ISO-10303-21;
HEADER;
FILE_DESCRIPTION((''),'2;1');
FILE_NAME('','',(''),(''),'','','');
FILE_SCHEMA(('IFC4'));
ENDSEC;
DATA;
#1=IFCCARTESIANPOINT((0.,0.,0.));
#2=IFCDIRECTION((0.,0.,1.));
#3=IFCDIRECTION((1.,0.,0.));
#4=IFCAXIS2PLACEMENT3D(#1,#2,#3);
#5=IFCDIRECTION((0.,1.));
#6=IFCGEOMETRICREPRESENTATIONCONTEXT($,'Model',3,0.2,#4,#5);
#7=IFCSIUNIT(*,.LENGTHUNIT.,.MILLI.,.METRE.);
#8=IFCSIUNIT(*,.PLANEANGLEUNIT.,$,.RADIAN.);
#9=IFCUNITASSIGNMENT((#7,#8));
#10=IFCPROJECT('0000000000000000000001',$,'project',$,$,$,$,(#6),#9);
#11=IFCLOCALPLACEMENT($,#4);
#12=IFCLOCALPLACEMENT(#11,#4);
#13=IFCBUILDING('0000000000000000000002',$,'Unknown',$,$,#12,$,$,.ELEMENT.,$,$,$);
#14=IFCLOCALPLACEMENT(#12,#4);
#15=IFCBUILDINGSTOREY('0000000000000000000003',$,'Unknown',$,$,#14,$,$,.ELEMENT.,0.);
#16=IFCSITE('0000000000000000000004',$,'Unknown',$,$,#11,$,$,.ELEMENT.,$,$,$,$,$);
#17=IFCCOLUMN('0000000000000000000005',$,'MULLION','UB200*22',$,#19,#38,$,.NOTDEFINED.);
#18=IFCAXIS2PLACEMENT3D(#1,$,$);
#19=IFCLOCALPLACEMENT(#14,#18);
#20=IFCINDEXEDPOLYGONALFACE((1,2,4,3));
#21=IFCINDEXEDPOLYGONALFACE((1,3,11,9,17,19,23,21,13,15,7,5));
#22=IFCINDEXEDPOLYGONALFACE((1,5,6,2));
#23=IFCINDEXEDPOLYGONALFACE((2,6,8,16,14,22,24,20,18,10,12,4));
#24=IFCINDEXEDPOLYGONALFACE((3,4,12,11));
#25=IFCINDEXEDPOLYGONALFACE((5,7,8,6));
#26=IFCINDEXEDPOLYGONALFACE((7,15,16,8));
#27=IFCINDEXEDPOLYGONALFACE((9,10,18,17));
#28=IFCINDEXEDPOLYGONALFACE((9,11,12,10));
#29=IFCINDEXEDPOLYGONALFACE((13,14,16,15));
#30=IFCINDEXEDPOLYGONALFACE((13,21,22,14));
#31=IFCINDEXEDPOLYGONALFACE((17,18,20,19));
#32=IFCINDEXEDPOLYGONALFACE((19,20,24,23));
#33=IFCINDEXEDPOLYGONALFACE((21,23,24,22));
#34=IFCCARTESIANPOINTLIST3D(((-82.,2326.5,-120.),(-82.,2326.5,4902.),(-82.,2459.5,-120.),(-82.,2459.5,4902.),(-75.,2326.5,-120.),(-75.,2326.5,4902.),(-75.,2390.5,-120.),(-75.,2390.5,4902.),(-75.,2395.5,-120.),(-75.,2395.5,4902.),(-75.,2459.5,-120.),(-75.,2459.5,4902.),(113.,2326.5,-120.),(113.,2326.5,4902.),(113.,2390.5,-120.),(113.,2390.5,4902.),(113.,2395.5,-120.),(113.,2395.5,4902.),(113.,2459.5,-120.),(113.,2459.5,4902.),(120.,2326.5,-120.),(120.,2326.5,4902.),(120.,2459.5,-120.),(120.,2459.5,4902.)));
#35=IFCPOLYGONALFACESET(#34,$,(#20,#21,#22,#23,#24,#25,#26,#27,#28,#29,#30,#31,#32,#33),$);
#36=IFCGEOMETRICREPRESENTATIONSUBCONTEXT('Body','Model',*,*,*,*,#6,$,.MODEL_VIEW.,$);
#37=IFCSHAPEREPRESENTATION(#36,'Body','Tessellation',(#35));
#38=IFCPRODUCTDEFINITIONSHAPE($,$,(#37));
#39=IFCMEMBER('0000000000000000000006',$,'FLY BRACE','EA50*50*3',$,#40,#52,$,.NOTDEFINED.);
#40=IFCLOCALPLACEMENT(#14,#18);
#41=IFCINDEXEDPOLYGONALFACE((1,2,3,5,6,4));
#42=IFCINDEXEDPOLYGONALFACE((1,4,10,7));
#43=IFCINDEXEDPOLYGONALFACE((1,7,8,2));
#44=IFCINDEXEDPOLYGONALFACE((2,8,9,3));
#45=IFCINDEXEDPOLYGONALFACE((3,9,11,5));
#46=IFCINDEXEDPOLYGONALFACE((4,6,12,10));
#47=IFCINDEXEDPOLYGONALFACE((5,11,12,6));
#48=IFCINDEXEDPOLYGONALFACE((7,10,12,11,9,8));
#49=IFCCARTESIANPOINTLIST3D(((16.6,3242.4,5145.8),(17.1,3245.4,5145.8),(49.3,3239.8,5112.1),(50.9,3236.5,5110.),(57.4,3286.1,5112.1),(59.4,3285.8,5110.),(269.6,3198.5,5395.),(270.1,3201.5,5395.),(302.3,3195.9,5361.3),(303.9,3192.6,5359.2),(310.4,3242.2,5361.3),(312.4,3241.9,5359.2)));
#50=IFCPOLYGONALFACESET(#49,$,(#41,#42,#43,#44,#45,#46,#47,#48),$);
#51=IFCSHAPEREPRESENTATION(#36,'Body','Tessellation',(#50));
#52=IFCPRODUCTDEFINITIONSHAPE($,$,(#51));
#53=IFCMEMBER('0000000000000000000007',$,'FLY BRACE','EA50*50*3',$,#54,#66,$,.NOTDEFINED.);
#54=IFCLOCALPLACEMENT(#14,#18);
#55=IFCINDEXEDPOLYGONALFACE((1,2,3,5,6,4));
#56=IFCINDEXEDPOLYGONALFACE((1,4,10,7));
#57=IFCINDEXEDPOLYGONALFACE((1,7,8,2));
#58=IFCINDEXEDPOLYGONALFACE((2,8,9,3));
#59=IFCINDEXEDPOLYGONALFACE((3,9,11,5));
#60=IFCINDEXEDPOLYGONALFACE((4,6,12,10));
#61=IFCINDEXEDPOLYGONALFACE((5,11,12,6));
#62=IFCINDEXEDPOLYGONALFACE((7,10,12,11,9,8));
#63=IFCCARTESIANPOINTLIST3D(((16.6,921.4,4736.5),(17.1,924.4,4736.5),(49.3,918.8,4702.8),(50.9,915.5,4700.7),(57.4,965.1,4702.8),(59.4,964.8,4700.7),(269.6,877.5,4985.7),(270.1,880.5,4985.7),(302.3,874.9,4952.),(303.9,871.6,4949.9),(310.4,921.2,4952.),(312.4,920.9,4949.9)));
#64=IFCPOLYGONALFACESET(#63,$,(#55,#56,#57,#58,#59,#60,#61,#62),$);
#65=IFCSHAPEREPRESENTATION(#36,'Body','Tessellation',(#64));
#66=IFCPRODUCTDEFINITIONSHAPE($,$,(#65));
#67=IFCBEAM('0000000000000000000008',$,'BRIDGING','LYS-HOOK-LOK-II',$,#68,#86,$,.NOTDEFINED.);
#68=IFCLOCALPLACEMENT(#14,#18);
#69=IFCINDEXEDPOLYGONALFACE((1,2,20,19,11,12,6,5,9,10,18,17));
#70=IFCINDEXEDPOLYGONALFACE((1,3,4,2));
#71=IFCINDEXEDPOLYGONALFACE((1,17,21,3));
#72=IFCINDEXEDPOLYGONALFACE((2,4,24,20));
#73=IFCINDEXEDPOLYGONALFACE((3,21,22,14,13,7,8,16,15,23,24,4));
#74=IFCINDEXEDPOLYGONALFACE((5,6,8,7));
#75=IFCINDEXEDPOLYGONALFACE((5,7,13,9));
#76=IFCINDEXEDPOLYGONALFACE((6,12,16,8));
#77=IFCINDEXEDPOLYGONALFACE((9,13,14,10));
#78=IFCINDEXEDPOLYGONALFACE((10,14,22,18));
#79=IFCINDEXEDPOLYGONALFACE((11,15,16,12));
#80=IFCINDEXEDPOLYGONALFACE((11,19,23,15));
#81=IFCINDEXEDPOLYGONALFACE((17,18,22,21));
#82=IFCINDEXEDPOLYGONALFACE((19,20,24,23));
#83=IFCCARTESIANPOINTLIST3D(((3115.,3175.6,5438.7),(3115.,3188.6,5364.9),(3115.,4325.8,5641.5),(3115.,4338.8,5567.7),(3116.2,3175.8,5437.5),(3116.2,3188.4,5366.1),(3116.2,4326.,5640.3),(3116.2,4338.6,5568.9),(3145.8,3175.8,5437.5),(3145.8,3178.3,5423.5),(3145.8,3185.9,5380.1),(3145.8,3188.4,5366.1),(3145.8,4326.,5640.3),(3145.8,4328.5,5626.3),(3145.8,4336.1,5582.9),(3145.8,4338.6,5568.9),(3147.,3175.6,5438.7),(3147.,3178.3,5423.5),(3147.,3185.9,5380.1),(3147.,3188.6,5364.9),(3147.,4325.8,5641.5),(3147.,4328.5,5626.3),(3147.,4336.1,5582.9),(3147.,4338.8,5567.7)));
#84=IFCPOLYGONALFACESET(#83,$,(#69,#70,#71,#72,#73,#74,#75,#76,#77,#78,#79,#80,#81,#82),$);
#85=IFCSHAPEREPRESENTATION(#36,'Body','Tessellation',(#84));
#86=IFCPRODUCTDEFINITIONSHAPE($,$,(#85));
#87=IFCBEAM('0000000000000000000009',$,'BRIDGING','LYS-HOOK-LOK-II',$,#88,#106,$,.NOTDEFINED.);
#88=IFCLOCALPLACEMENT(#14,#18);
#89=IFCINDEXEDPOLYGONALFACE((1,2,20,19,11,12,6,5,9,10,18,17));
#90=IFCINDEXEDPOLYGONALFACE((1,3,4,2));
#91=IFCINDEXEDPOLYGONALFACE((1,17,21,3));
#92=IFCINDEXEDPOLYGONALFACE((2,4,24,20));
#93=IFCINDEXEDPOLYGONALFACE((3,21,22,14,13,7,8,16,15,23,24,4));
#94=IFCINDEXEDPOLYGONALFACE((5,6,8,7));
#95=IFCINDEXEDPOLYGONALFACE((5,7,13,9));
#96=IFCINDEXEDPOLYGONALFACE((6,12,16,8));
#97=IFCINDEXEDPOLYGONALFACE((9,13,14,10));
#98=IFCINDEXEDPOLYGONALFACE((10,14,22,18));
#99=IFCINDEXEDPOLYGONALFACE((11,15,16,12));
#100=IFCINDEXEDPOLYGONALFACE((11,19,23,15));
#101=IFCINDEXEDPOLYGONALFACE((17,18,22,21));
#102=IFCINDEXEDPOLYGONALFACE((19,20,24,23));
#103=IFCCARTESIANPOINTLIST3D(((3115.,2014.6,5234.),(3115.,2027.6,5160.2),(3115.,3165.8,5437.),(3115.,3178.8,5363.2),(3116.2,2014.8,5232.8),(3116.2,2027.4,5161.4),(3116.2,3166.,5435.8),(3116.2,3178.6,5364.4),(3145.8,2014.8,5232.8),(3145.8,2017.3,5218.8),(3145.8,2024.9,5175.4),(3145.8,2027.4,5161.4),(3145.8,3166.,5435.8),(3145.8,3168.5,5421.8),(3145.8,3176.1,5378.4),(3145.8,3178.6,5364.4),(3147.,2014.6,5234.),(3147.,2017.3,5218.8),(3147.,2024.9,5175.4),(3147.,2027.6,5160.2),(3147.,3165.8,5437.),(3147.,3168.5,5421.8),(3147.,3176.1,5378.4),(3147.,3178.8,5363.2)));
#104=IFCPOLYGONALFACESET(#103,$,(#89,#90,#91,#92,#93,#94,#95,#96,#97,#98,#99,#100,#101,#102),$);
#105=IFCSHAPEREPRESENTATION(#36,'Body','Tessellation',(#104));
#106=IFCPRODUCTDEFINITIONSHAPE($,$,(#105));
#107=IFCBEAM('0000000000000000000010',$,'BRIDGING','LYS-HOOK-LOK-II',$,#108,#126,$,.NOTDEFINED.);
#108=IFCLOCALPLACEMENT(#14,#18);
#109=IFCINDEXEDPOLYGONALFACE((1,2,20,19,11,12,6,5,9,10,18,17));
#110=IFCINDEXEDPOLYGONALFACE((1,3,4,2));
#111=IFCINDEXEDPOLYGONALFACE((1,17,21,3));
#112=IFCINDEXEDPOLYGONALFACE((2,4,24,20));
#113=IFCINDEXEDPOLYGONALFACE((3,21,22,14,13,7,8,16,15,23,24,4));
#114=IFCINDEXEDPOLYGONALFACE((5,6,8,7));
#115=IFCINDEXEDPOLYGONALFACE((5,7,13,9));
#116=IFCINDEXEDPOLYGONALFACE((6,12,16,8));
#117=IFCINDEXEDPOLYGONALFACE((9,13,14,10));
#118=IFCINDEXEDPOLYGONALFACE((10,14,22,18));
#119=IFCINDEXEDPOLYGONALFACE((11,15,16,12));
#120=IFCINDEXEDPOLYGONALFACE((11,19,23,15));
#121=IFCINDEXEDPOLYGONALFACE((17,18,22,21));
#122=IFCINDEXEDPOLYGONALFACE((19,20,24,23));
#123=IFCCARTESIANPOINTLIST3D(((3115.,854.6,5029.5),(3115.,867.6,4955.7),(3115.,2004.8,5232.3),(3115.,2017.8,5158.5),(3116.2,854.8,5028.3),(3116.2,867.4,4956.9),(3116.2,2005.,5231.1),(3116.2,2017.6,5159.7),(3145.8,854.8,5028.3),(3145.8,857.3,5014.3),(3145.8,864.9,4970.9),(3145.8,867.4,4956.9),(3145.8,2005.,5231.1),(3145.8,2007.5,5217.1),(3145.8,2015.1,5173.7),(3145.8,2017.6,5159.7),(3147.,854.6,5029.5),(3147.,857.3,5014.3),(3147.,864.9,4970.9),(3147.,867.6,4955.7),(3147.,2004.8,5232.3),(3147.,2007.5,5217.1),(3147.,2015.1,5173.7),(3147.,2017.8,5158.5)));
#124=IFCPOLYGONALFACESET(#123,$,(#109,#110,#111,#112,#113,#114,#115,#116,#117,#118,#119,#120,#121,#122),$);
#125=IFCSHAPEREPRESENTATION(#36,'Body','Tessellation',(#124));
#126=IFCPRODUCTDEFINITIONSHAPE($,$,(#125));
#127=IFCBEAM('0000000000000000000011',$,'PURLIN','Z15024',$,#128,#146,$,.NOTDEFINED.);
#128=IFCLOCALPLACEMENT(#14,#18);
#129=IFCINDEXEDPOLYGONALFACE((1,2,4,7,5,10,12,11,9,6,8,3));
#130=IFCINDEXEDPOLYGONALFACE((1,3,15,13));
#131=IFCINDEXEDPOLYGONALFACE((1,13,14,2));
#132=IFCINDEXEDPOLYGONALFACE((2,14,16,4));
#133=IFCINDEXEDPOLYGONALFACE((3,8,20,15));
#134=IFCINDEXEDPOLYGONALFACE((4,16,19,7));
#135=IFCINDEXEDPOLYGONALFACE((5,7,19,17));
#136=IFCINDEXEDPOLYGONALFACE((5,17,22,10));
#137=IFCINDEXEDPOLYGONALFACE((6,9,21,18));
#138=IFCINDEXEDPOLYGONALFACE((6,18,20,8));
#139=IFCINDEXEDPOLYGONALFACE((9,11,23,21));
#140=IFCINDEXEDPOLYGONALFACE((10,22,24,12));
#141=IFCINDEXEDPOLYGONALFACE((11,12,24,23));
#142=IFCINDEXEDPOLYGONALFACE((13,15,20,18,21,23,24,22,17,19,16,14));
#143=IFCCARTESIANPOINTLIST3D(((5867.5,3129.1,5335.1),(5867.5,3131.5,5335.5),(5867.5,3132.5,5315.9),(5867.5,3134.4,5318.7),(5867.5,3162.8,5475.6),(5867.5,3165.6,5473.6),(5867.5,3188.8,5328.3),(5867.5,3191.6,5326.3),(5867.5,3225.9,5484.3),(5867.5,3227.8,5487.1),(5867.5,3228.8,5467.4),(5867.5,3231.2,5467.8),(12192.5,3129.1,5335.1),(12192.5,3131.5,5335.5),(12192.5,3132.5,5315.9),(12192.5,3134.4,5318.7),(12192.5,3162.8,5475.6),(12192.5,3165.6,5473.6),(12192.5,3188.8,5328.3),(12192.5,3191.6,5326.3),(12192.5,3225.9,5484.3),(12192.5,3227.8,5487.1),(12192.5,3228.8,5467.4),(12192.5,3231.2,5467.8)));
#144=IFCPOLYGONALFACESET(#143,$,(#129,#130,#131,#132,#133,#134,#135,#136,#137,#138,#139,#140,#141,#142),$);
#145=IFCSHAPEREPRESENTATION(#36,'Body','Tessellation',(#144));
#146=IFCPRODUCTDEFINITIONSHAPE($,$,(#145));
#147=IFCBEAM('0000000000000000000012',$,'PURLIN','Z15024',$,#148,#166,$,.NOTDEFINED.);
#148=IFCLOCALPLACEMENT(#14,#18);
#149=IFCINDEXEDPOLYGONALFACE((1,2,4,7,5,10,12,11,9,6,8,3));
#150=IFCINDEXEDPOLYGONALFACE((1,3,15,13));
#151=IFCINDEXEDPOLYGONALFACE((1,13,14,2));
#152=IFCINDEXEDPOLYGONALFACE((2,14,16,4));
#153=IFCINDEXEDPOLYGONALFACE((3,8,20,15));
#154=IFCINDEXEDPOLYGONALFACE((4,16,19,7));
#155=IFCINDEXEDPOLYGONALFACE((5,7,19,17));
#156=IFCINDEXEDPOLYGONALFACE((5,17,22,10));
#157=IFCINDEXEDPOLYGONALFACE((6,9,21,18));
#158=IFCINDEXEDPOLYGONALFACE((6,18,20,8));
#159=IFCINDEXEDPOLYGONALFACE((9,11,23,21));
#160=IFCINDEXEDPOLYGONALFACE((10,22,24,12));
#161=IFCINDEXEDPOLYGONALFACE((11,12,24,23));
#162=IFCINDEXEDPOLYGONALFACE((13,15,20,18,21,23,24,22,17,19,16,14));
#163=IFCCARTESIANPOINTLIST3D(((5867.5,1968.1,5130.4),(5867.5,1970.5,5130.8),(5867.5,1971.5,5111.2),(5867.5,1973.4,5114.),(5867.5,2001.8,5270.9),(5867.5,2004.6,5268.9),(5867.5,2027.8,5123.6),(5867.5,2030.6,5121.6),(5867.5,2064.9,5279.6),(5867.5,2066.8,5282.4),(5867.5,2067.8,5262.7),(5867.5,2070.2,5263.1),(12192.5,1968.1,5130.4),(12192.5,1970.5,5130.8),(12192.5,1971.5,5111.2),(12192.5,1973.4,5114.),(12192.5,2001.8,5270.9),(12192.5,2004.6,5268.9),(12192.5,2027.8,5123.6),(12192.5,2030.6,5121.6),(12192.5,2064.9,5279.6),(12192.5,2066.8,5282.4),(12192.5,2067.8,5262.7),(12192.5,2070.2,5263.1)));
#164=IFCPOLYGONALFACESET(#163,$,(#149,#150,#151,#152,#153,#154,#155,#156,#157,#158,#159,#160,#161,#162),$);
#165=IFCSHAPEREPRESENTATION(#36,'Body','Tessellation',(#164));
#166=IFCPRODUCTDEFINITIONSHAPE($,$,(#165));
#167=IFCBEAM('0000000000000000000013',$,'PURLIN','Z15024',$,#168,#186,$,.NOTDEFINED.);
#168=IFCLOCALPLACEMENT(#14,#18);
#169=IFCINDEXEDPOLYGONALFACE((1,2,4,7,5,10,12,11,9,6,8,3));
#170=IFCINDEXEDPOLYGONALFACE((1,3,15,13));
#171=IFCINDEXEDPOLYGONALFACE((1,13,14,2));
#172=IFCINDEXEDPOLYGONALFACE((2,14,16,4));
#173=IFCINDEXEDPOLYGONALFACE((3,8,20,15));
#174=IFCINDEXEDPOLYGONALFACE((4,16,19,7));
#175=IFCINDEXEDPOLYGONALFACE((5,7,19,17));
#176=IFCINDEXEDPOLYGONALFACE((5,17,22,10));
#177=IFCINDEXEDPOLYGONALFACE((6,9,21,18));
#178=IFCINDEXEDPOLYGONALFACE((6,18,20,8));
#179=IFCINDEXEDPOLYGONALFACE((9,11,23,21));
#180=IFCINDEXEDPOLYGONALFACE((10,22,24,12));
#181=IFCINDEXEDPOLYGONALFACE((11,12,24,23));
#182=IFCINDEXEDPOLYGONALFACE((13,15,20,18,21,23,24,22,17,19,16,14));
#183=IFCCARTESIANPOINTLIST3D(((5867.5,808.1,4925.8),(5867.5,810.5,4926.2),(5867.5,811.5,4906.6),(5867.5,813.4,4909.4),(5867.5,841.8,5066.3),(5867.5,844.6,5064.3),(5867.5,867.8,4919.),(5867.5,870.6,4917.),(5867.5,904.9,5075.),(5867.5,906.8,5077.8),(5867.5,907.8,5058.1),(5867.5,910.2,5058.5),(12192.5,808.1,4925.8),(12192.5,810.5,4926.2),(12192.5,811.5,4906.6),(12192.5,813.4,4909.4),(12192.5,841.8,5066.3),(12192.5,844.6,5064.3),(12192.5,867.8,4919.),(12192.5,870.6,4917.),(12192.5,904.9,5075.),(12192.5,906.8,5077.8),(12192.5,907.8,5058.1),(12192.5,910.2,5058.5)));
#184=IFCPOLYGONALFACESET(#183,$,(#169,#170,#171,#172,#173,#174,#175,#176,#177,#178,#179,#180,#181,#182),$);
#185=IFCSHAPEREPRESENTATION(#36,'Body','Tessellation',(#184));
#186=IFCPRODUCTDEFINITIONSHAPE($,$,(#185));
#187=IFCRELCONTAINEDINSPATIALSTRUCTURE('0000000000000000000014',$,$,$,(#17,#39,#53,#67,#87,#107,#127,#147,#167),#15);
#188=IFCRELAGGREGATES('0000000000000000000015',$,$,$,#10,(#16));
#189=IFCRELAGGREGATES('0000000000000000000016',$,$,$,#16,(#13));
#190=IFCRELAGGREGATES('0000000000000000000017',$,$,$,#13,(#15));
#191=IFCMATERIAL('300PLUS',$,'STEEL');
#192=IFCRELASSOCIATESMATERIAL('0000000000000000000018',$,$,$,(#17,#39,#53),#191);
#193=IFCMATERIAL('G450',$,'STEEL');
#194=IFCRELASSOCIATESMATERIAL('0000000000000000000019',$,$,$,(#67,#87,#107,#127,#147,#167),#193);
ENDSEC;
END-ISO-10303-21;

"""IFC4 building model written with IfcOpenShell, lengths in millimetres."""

from ifc_helpers import new_model, si_unit, direction, frame, origin_with_axes, place, context, subcontext, project, spatial, line, indexed_curve, outline, extrude, material, element, save


model = new_model("IFC4")

# Units and contexts
model_context = context("Model", 3, precision=0.2, world=origin_with_axes(), true_north=direction((0.0, 1.0)))
body_context = subcontext(model_context, "Body", "Model", "MODEL_VIEW")
ifc_project = project(units=[si_unit("LENGTHUNIT", "METRE", prefix="MILLI"), si_unit("PLANEANGLEUNIT", "RADIAN")], contexts=[model_context])

# Site, building, storey
site_placement = place(None, origin_with_axes())
site = spatial("IfcSite", under=ifc_project, at=site_placement, Name="Unknown", CompositionType="ELEMENT")
building_placement = place(site_placement, origin_with_axes())
building = spatial("IfcBuilding", under=site, at=building_placement, Name="Unknown", CompositionType="ELEMENT")
storey_placement = place(building_placement, origin_with_axes())
storey = spatial("IfcBuildingStorey", under=building, at=storey_placement, Name="Unknown", CompositionType="ELEMENT", Elevation=0.0)

# Column
ifc_material_1 = material(Name="300PLUS", Category="STEEL")
column_placement = place(storey_placement, frame((19.0, 2393.0, -120.0), z_axis=(0.0, -1.0, 0.0), x_axis=(0.0, 0.0, 1.0)))
element("IfcColumn", 1, at=column_placement, inside=storey, material=ifc_material_1, Name="MULLION", Description="UB200*22", PredefinedType="NOTDEFINED", context=body_context, shape_type="SolidModel", body=[
    extrude(outline(indexed_curve([(-66.5, -101.0), (66.5, -101.0), (66.5, -94.0), (2.5, -94.0), (2.5, 94.0), (66.5, 94.0), (66.5, 101.0), (-66.5, 101.0), (-66.5, 94.0), (-2.5, 94.0), (-2.5, -94.0), (-66.5, -94.0)], segments=[line(1, 2, 3, 4, 5, 6, 7, 8, 9, 10, 11, 12, 1)])), frame((0.0, 0.0, 0.0), z_axis=(-1.0, 0.0, 0.0), x_axis=(0.0, 0.0, 1.0)), (0.0, 0.0, -1.0), 5022.0),
])

# Members
for number, where, z_axis, x_axis, name in (
    (2, (291.0, 3220.2, 5377.1), (0.170963, 0.985277, 0.0), (-0.707055, 0.122687, -0.696435), "FLY BRACE"),
    (3, (291.0, 899.2, 4967.8), (0.170963, 0.985277, 0.0), (-0.707055, 0.122687, -0.696435), "FLY BRACE"),
):
    element("IfcMember", number, at=place(storey_placement, frame(where, z_axis=z_axis, x_axis=x_axis)), inside=storey, material=ifc_material_1, Name=name, Description="EA50*50*3", PredefinedType="NOTDEFINED", context=body_context, shape_type="SolidModel", body=[
        extrude(outline(indexed_curve([(-25.0, -25.0), (25.0, -25.0), (25.0, -22.0), (-22.0, -22.0), (-22.0, 25.0), (-25.0, 25.0)], segments=[line(1, 2, 3, 4, 5, 6, 1)])), frame((0.0, 0.0, 0.0), z_axis=(-1.0, 0.0, 0.0), x_axis=(0.0, 0.0, 1.0)), (0.0, 0.0, -1.0), 357.8),
    ])

# Beams
ifc_material_2 = material(Name="G450", Category="STEEL")
beam_1_placement = place(storey_placement, frame((3131.0, 3182.1, 5401.8), z_axis=(1.0, 0.0, 0.0), x_axis=(0.0, 0.984809, 0.173639)))
element("IfcBeam", 4, at=beam_1_placement, inside=storey, material=ifc_material_2, Name="BRIDGING", Description="LYS-HOOK-LOK-II", PredefinedType="NOTDEFINED", context=body_context, shape_type="SolidModel", body=[
    extrude(outline(indexed_curve([(16.0, -37.5), (16.0, -22.0), (14.8, -22.0), (14.8, -36.3), (-14.8, -36.3), (-14.8, 36.3), (14.8, 36.3), (14.8, 22.0), (16.0, 22.0), (16.0, 37.5), (-16.0, 37.5), (-16.0, -37.5)], segments=[line(1, 2, 3, 4, 5, 6, 7, 8, 9, 10, 11, 12, 1)])), frame((0.0, 0.0, 0.0), z_axis=(-1.0, 0.0, 0.0), x_axis=(0.0, 0.0, 1.0)), (0.0, 0.0, -1.0), 1167.9),
])
beam_2_placement = place(storey_placement, frame((3131.0, 2021.1, 5197.1), z_axis=(1.0, 0.0, 0.0), x_axis=(0.0, 0.984806, 0.173658)))
element("IfcBeam", 5, at=beam_2_placement, inside=storey, material=ifc_material_2, Name="BRIDGING", Description="LYS-HOOK-LOK-II", PredefinedType="NOTDEFINED", context=body_context, shape_type="SolidModel", body=[
    extrude(outline(indexed_curve([(16.0, -37.5), (16.0, -22.0), (14.8, -22.0), (14.8, -36.3), (-14.8, -36.3), (-14.8, 36.3), (14.8, 36.3), (14.8, 22.0), (16.0, 22.0), (16.0, 37.5), (-16.0, 37.5), (-16.0, -37.5)], segments=[line(1, 2, 3, 4, 5, 6, 7, 8, 9, 10, 11, 12, 1)])), frame((0.0, 0.0, 0.0), z_axis=(-1.0, 0.0, 0.0), x_axis=(0.0, 0.0, 1.0)), (0.0, 0.0, -1.0), 1169.0),
])
beam_3_placement = place(storey_placement, frame((3131.0, 861.1, 4992.6), z_axis=(1.0, 0.0, 0.0), x_axis=(0.0, 0.984809, 0.173639)))
element("IfcBeam", 6, at=beam_3_placement, inside=storey, material=ifc_material_2, Name="BRIDGING", Description="LYS-HOOK-LOK-II", PredefinedType="NOTDEFINED", context=body_context, shape_type="SolidModel", body=[
    extrude(outline(indexed_curve([(16.0, -37.5), (16.0, -22.0), (14.8, -22.0), (14.8, -36.3), (-14.8, -36.3), (-14.8, 36.3), (14.8, 36.3), (14.8, 22.0), (16.0, 22.0), (16.0, 37.5), (-16.0, 37.5), (-16.0, -37.5)], segments=[line(1, 2, 3, 4, 5, 6, 7, 8, 9, 10, 11, 12, 1)])), frame((0.0, 0.0, 0.0), z_axis=(-1.0, 0.0, 0.0), x_axis=(0.0, 0.0, 1.0)), (0.0, 0.0, -1.0), 1167.9),
])
for number, where, z_axis, x_axis, name in (
    (7, (5867.5, 3177.2, 5401.0), (0.0, -0.984808, -0.173648), (1.0, 0.0, 0.0), "PURLIN"),
    (8, (5867.5, 2016.2, 5196.3), (0.0, -0.984808, -0.173648), (1.0, 0.0, 0.0), "PURLIN"),
    (9, (5867.5, 856.2, 4991.7), (0.0, -0.984808, -0.173648), (1.0, 0.0, 0.0), "PURLIN"),
):
    element("IfcBeam", number, at=place(storey_placement, frame(where, z_axis=z_axis, x_axis=x_axis)), inside=storey, material=ifc_material_2, Name=name, Description="Z15024", PredefinedType="NOTDEFINED", context=body_context, shape_type="SolidModel", body=[
        extrude(outline(indexed_curve([(58.8, -76.0), (58.8, -56.5), (56.4, -56.5), (56.4, -73.6), (1.2, -73.6), (1.2, 76.0), (-64.8, 76.0), (-64.8, 56.5), (-62.4, 56.5), (-62.4, 73.6), (-1.2, 73.6), (-1.2, -76.0)], segments=[line(1, 2, 3, 4, 5, 6, 7, 8, 9, 10, 11, 12, 1)])), frame((0.0, 0.0, 0.0), z_axis=(-1.0, 0.0, 0.0), x_axis=(0.0, 0.0, 1.0)), (0.0, 0.0, -1.0), 6325.0),
    ])

save(model, "model.ifc")
